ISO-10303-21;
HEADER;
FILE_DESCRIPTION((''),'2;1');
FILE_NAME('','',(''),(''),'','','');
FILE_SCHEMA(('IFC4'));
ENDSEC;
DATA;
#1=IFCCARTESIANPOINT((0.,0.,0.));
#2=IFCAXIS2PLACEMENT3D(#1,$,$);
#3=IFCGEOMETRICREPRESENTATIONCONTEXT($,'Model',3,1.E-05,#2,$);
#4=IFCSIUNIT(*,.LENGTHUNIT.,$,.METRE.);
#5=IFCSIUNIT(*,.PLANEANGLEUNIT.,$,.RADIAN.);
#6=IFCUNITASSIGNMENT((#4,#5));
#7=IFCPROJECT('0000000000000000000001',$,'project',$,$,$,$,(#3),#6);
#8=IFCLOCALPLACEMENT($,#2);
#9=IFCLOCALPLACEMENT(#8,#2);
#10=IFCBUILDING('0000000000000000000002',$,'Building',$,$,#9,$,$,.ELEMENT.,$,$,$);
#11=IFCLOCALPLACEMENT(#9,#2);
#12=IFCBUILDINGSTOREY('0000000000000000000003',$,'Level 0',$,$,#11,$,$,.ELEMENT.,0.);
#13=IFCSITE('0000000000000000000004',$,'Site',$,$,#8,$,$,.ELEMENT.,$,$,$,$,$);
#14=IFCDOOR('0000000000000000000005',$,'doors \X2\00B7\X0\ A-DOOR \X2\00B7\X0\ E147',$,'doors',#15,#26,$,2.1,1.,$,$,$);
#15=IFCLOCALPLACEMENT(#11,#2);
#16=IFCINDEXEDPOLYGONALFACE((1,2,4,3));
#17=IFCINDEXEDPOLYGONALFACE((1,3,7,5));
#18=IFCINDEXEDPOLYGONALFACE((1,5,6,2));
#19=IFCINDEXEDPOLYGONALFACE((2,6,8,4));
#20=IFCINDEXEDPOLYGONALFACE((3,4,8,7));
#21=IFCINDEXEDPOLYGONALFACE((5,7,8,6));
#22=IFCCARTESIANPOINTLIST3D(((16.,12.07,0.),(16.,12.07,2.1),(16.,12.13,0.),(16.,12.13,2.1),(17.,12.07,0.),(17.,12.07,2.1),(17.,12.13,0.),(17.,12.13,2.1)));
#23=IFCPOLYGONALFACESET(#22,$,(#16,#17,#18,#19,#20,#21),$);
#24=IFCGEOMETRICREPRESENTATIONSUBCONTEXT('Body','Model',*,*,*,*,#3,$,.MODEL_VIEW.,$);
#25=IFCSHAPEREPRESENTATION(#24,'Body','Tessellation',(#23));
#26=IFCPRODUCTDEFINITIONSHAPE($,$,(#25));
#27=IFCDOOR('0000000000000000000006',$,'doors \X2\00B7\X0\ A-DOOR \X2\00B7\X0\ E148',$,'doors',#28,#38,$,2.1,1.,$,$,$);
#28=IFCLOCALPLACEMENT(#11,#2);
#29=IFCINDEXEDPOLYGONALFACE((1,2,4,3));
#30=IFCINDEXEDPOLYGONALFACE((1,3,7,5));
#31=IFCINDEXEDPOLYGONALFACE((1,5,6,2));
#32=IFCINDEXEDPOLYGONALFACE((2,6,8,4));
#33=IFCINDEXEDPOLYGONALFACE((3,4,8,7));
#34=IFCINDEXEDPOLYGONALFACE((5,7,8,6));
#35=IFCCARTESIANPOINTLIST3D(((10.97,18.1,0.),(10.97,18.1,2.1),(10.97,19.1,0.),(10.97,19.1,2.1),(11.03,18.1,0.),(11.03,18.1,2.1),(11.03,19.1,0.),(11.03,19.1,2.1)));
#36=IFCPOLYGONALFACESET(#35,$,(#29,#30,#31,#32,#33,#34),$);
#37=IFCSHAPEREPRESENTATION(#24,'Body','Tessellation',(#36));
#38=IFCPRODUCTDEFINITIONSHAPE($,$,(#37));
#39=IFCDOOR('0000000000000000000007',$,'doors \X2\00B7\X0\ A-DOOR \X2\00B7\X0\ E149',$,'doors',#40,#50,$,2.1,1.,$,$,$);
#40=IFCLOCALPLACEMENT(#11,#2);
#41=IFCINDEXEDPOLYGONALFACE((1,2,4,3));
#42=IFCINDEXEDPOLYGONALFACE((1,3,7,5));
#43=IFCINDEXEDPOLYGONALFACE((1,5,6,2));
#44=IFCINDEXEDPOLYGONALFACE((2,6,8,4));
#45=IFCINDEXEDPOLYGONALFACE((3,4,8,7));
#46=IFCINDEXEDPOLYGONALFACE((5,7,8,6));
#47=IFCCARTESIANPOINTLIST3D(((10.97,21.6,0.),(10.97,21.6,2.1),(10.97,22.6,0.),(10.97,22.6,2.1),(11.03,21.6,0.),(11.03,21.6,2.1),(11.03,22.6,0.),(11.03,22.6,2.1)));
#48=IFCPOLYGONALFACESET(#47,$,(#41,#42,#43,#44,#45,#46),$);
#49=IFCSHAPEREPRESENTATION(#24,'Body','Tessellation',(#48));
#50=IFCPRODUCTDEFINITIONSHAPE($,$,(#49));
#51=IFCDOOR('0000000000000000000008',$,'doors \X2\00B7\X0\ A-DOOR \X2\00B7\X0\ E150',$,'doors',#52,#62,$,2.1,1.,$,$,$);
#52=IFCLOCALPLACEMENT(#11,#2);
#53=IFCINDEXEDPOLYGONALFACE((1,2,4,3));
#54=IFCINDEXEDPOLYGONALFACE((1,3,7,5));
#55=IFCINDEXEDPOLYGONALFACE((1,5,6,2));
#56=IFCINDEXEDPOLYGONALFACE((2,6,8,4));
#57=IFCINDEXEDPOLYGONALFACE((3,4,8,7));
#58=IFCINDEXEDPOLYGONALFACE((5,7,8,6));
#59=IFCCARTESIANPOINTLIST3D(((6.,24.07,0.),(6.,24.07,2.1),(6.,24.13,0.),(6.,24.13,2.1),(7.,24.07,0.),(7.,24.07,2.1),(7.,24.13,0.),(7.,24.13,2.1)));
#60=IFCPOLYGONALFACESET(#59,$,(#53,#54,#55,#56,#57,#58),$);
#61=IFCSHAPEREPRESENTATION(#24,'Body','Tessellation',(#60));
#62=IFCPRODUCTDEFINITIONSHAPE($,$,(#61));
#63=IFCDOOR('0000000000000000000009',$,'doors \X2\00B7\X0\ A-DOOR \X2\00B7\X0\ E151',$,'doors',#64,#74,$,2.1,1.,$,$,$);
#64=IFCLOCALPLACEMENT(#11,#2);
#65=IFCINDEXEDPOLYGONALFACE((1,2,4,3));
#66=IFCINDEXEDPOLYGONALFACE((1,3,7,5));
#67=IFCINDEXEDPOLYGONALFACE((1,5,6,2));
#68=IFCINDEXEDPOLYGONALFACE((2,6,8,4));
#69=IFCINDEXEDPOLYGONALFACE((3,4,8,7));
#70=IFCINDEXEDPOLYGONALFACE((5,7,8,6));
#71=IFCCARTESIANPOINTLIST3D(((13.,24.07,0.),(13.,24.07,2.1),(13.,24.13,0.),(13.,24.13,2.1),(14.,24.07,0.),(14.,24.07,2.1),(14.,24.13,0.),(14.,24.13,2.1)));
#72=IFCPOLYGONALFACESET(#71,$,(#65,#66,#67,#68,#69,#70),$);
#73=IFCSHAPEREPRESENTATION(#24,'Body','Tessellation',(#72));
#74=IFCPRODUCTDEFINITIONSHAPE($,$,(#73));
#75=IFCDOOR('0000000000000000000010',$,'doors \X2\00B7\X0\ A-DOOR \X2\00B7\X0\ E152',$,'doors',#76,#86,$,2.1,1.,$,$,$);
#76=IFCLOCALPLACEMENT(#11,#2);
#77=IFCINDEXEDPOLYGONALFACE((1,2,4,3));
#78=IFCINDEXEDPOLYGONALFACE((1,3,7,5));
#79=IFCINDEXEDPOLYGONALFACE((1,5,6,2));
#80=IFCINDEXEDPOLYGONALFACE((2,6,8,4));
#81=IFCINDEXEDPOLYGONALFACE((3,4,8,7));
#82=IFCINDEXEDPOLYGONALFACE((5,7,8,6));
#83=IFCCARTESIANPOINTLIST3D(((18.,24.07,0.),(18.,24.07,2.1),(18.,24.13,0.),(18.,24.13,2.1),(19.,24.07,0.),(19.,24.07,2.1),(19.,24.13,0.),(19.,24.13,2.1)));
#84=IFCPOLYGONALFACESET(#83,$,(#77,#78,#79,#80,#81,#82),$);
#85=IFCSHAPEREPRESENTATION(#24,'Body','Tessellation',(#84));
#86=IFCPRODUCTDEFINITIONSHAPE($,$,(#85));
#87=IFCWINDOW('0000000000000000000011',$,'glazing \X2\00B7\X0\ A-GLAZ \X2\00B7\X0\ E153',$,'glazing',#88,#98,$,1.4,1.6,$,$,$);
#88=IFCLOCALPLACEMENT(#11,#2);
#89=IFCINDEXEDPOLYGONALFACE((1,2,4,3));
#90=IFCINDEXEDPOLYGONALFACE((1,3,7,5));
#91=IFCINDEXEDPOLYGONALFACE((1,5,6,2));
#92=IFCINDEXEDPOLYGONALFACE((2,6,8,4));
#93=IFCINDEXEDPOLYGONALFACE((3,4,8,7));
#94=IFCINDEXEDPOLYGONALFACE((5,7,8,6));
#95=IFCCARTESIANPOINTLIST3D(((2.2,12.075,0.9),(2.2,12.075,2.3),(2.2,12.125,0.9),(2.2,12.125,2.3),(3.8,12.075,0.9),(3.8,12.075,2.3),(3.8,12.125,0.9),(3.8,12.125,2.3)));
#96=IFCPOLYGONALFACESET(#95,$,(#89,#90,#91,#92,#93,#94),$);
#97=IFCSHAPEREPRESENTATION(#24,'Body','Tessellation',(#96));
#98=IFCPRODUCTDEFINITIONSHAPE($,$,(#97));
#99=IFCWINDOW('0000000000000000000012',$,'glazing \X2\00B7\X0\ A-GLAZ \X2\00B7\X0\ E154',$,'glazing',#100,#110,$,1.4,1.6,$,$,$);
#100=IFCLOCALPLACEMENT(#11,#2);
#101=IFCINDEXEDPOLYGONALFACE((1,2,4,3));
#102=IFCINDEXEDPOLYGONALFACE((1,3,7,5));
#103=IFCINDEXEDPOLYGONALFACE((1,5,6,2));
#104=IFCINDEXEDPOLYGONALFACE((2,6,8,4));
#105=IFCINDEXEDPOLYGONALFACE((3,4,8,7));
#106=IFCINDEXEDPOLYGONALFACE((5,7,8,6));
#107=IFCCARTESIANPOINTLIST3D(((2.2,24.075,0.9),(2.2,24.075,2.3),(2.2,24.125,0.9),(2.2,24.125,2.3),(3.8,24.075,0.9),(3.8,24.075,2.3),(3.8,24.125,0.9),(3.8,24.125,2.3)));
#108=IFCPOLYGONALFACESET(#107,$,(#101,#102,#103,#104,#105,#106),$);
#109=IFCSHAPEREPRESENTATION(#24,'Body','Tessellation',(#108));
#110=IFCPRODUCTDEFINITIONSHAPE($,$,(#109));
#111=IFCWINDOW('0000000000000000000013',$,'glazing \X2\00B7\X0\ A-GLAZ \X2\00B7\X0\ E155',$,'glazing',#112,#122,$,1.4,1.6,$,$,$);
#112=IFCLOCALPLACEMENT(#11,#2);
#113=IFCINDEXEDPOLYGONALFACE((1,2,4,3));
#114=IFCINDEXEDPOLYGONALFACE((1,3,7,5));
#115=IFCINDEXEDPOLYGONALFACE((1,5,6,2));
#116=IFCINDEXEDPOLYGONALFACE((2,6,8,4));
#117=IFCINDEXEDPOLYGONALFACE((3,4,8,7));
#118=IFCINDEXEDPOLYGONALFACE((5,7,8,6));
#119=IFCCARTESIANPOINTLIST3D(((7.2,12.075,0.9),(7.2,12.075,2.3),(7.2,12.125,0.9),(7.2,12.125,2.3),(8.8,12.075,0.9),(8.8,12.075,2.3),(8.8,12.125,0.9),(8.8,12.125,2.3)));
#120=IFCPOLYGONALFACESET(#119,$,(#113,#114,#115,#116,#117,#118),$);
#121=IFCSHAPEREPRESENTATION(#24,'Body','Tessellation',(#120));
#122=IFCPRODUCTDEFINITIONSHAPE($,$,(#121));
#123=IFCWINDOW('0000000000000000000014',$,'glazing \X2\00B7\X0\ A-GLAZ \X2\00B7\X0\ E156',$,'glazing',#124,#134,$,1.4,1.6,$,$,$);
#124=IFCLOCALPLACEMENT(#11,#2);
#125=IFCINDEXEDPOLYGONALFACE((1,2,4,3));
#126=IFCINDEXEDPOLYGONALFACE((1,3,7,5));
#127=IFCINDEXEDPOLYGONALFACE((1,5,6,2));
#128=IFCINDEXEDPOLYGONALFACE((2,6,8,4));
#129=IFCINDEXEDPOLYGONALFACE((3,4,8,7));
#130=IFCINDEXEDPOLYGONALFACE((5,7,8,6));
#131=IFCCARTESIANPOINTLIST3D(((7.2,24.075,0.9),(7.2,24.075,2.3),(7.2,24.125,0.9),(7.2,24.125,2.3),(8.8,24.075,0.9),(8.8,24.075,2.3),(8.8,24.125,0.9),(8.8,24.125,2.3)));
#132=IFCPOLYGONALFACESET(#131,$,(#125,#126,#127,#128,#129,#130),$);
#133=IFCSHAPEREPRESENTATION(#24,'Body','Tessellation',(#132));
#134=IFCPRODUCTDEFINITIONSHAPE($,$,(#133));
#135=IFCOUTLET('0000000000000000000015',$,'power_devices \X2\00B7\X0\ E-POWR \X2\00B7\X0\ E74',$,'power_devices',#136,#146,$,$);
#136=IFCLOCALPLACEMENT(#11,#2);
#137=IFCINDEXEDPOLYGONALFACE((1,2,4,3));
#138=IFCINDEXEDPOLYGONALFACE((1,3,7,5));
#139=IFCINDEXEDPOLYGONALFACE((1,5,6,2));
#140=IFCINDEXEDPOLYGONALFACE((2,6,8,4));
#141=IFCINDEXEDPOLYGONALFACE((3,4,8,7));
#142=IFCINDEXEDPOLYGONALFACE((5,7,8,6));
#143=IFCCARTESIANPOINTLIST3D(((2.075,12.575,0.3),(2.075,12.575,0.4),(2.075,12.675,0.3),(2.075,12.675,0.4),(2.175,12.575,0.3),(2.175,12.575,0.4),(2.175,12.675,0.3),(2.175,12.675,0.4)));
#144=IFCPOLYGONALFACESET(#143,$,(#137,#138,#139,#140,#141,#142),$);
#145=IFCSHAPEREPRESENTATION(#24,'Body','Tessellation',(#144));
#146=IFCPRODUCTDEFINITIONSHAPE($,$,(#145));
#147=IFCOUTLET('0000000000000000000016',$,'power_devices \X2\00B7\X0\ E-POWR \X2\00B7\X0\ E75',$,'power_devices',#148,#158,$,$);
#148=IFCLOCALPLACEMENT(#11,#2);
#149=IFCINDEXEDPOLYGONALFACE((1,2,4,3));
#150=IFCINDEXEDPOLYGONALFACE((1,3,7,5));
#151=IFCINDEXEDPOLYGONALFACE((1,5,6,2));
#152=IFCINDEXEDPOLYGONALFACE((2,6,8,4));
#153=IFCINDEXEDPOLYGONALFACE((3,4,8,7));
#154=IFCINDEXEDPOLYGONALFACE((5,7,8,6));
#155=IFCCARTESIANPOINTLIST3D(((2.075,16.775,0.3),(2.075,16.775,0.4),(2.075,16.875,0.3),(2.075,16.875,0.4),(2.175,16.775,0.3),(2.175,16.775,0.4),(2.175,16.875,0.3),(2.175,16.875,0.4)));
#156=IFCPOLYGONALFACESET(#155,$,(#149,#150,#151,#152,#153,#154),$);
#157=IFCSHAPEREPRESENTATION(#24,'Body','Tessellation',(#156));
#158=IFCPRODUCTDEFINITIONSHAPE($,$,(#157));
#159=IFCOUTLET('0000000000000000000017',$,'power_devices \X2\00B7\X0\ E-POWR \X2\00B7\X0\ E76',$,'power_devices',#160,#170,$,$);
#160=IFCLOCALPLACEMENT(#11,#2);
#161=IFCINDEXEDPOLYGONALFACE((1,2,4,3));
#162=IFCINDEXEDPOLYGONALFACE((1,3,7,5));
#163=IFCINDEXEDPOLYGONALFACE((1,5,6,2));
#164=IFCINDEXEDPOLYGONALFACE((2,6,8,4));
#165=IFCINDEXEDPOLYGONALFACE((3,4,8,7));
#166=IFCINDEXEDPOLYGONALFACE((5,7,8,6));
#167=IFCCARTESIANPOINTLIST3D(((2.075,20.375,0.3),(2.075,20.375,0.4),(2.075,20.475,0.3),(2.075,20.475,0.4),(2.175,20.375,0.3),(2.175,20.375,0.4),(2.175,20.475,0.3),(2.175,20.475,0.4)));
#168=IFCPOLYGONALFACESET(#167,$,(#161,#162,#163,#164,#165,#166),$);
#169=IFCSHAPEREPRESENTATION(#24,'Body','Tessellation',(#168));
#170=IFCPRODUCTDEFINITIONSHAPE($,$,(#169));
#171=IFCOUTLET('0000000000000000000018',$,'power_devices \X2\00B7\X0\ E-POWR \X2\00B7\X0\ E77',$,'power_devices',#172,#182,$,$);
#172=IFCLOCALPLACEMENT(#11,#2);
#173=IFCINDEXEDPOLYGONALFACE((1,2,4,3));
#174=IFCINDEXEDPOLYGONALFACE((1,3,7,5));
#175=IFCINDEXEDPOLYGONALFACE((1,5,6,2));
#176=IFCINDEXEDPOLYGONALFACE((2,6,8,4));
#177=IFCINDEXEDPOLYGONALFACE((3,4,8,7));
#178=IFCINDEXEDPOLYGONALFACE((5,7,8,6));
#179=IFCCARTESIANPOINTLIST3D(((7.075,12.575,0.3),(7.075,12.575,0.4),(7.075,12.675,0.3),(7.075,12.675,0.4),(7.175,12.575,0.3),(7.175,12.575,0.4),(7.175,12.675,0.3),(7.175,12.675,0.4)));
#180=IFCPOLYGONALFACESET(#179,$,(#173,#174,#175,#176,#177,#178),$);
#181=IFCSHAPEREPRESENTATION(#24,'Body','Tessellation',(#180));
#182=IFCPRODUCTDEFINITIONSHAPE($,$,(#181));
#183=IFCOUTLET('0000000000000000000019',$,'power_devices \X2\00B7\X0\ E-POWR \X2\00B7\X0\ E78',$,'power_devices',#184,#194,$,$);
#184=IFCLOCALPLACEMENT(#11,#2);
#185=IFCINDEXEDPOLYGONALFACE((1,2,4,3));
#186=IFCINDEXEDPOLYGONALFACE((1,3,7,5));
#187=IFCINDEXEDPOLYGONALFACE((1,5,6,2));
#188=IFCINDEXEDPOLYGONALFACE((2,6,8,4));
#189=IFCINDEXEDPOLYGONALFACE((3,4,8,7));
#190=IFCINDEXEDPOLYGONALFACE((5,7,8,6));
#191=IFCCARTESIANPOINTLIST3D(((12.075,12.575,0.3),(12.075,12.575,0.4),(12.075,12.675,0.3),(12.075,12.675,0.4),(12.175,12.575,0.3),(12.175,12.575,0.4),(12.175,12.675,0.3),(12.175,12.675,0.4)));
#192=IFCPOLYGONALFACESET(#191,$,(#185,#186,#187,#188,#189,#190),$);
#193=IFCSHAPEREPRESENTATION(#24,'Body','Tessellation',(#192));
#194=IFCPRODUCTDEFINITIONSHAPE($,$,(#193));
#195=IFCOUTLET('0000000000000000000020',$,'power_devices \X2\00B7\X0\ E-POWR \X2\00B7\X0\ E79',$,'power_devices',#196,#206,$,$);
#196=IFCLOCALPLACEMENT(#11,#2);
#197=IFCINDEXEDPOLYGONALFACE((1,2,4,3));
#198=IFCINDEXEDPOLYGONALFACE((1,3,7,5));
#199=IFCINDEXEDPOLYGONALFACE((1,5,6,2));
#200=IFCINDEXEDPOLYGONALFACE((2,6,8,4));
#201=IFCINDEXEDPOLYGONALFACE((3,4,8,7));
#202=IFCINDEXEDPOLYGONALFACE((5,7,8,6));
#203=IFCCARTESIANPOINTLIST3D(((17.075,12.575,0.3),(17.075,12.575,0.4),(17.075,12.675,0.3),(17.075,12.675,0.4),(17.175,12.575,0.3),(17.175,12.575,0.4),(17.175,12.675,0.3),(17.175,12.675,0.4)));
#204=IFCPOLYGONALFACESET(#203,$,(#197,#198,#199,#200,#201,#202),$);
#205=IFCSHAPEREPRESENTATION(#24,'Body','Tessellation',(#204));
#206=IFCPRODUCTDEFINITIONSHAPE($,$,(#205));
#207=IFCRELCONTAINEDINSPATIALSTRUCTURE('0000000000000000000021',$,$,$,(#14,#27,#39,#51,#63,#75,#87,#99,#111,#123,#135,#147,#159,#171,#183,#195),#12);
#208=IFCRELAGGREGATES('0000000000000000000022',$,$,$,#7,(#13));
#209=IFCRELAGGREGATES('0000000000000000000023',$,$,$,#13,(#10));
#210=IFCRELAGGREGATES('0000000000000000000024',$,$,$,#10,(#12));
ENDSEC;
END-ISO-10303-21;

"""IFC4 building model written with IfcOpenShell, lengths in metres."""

from ifc_helpers import new_model, si_unit, frame, origin, place, context, subcontext, project, spatial, polyline, outline, extrude, element, save


model = new_model("IFC4")

# Units and contexts
model_context = context("Model", 3, precision=1e-05, world=origin())
body_context = subcontext(model_context, "Body", "Model", "MODEL_VIEW")
ifc_project = project(units=[si_unit("LENGTHUNIT", "METRE"), si_unit("PLANEANGLEUNIT", "RADIAN")], contexts=[model_context])

# Site, building, storey
site_placement = place(None, origin())
site = spatial("IfcSite", under=ifc_project, at=site_placement, Name="Site", CompositionType="ELEMENT")
building_placement = place(site_placement, origin())
building = spatial("IfcBuilding", under=site, at=building_placement, Name="Building", CompositionType="ELEMENT")
storey_placement = place(building_placement, origin())
storey = spatial("IfcBuildingStorey", under=building, at=storey_placement, Name="Level 0", CompositionType="ELEMENT", Elevation=0.0)

# Doors
door_1_placement = place(storey_placement, origin())
element("IfcDoor", 1, at=door_1_placement, inside=storey, Name="doors · A-DOOR · E147", ObjectType="doors", OverallHeight=2.1, OverallWidth=1.0, context=body_context, shape_type="SweptSolid", body=[
    extrude(outline(polyline([(16.0, 12.07), (17.0, 12.07), (17.0, 12.13), (16.0, 12.13), (16.0, 12.07)])), origin(), (0.0, 0.0, 1.0), 2.1),
])
door_2_placement = place(storey_placement, origin())
element("IfcDoor", 2, at=door_2_placement, inside=storey, Name="doors · A-DOOR · E148", ObjectType="doors", OverallHeight=2.1, OverallWidth=1.0, context=body_context, shape_type="SweptSolid", body=[
    extrude(outline(polyline([(11.03, 18.1), (11.03, 19.1), (10.97, 19.1), (10.97, 18.1), (11.03, 18.1)])), origin(), (0.0, 0.0, 1.0), 2.1),
])
door_3_placement = place(storey_placement, origin())
element("IfcDoor", 3, at=door_3_placement, inside=storey, Name="doors · A-DOOR · E149", ObjectType="doors", OverallHeight=2.1, OverallWidth=1.0, context=body_context, shape_type="SweptSolid", body=[
    extrude(outline(polyline([(11.03, 21.6), (11.03, 22.6), (10.97, 22.6), (10.97, 21.6), (11.03, 21.6)])), origin(), (0.0, 0.0, 1.0), 2.1),
])
door_4_placement = place(storey_placement, origin())
element("IfcDoor", 4, at=door_4_placement, inside=storey, Name="doors · A-DOOR · E150", ObjectType="doors", OverallHeight=2.1, OverallWidth=1.0, context=body_context, shape_type="SweptSolid", body=[
    extrude(outline(polyline([(7.0, 24.13), (6.0, 24.13), (6.0, 24.07), (7.0, 24.07), (7.0, 24.13)])), origin(), (0.0, 0.0, 1.0), 2.1),
])
door_5_placement = place(storey_placement, origin())
element("IfcDoor", 5, at=door_5_placement, inside=storey, Name="doors · A-DOOR · E151", ObjectType="doors", OverallHeight=2.1, OverallWidth=1.0, context=body_context, shape_type="SweptSolid", body=[
    extrude(outline(polyline([(14.0, 24.13), (13.0, 24.13), (13.0, 24.07), (14.0, 24.07), (14.0, 24.13)])), origin(), (0.0, 0.0, 1.0), 2.1),
])
door_6_placement = place(storey_placement, origin())
element("IfcDoor", 6, at=door_6_placement, inside=storey, Name="doors · A-DOOR · E152", ObjectType="doors", OverallHeight=2.1, OverallWidth=1.0, context=body_context, shape_type="SweptSolid", body=[
    extrude(outline(polyline([(19.0, 24.13), (18.0, 24.13), (18.0, 24.07), (19.0, 24.07), (19.0, 24.13)])), origin(), (0.0, 0.0, 1.0), 2.1),
])

# Windows
window_1_placement = place(storey_placement, frame((0.0, 0.0, 0.9)))
element("IfcWindow", 7, at=window_1_placement, inside=storey, Name="glazing · A-GLAZ · E153", ObjectType="glazing", OverallHeight=1.4, OverallWidth=1.6, context=body_context, shape_type="SweptSolid", body=[
    extrude(outline(polyline([(2.2, 12.075), (3.8, 12.075), (3.8, 12.125), (2.2, 12.125), (2.2, 12.075)])), origin(), (0.0, 0.0, 1.0), 1.4),
])
window_2_placement = place(storey_placement, frame((0.0, 0.0, 0.9)))
element("IfcWindow", 8, at=window_2_placement, inside=storey, Name="glazing · A-GLAZ · E154", ObjectType="glazing", OverallHeight=1.4, OverallWidth=1.6, context=body_context, shape_type="SweptSolid", body=[
    extrude(outline(polyline([(3.8, 24.125), (2.2, 24.125), (2.2, 24.075), (3.8, 24.075), (3.8, 24.125)])), origin(), (0.0, 0.0, 1.0), 1.4),
])
window_3_placement = place(storey_placement, frame((0.0, 0.0, 0.9)))
element("IfcWindow", 9, at=window_3_placement, inside=storey, Name="glazing · A-GLAZ · E155", ObjectType="glazing", OverallHeight=1.4, OverallWidth=1.6, context=body_context, shape_type="SweptSolid", body=[
    extrude(outline(polyline([(7.2, 12.075), (8.8, 12.075), (8.8, 12.125), (7.2, 12.125), (7.2, 12.075)])), origin(), (0.0, 0.0, 1.0), 1.4),
])
window_4_placement = place(storey_placement, frame((0.0, 0.0, 0.9)))
element("IfcWindow", 10, at=window_4_placement, inside=storey, Name="glazing · A-GLAZ · E156", ObjectType="glazing", OverallHeight=1.4, OverallWidth=1.6, context=body_context, shape_type="SweptSolid", body=[
    extrude(outline(polyline([(8.8, 24.125), (7.2, 24.125), (7.2, 24.075), (8.8, 24.075), (8.8, 24.125)])), origin(), (0.0, 0.0, 1.0), 1.4),
])

# Outlets
outlet_1_placement = place(storey_placement, frame((0.0, 0.0, 0.3)))
element("IfcOutlet", 11, at=outlet_1_placement, inside=storey, Name="power_devices · E-POWR · E74", ObjectType="power_devices", context=body_context, shape_type="SweptSolid", body=[
    extrude(outline(polyline([(2.075, 12.575), (2.175, 12.575), (2.175, 12.675), (2.075, 12.675), (2.075, 12.575)])), origin(), (0.0, 0.0, 1.0), 0.1),
])
outlet_2_placement = place(storey_placement, frame((0.0, 0.0, 0.3)))
element("IfcOutlet", 12, at=outlet_2_placement, inside=storey, Name="power_devices · E-POWR · E75", ObjectType="power_devices", context=body_context, shape_type="SweptSolid", body=[
    extrude(outline(polyline([(2.075, 16.775), (2.175, 16.775), (2.175, 16.875), (2.075, 16.875), (2.075, 16.775)])), origin(), (0.0, 0.0, 1.0), 0.1),
])
outlet_3_placement = place(storey_placement, frame((0.0, 0.0, 0.3)))
element("IfcOutlet", 13, at=outlet_3_placement, inside=storey, Name="power_devices · E-POWR · E76", ObjectType="power_devices", context=body_context, shape_type="SweptSolid", body=[
    extrude(outline(polyline([(2.075, 20.375), (2.175, 20.375), (2.175, 20.475), (2.075, 20.475), (2.075, 20.375)])), origin(), (0.0, 0.0, 1.0), 0.1),
])
outlet_4_placement = place(storey_placement, frame((0.0, 0.0, 0.3)))
element("IfcOutlet", 14, at=outlet_4_placement, inside=storey, Name="power_devices · E-POWR · E77", ObjectType="power_devices", context=body_context, shape_type="SweptSolid", body=[
    extrude(outline(polyline([(7.075, 12.575), (7.175, 12.575), (7.175, 12.675), (7.075, 12.675), (7.075, 12.575)])), origin(), (0.0, 0.0, 1.0), 0.1),
])
outlet_5_placement = place(storey_placement, frame((0.0, 0.0, 0.3)))
element("IfcOutlet", 15, at=outlet_5_placement, inside=storey, Name="power_devices · E-POWR · E78", ObjectType="power_devices", context=body_context, shape_type="SweptSolid", body=[
    extrude(outline(polyline([(12.075, 12.575), (12.175, 12.575), (12.175, 12.675), (12.075, 12.675), (12.075, 12.575)])), origin(), (0.0, 0.0, 1.0), 0.1),
])
outlet_6_placement = place(storey_placement, frame((0.0, 0.0, 0.3)))
element("IfcOutlet", 16, at=outlet_6_placement, inside=storey, Name="power_devices · E-POWR · E79", ObjectType="power_devices", context=body_context, shape_type="SweptSolid", body=[
    extrude(outline(polyline([(17.075, 12.575), (17.175, 12.575), (17.175, 12.675), (17.075, 12.675), (17.075, 12.575)])), origin(), (0.0, 0.0, 1.0), 0.1),
])

save(model, "model.ifc")
